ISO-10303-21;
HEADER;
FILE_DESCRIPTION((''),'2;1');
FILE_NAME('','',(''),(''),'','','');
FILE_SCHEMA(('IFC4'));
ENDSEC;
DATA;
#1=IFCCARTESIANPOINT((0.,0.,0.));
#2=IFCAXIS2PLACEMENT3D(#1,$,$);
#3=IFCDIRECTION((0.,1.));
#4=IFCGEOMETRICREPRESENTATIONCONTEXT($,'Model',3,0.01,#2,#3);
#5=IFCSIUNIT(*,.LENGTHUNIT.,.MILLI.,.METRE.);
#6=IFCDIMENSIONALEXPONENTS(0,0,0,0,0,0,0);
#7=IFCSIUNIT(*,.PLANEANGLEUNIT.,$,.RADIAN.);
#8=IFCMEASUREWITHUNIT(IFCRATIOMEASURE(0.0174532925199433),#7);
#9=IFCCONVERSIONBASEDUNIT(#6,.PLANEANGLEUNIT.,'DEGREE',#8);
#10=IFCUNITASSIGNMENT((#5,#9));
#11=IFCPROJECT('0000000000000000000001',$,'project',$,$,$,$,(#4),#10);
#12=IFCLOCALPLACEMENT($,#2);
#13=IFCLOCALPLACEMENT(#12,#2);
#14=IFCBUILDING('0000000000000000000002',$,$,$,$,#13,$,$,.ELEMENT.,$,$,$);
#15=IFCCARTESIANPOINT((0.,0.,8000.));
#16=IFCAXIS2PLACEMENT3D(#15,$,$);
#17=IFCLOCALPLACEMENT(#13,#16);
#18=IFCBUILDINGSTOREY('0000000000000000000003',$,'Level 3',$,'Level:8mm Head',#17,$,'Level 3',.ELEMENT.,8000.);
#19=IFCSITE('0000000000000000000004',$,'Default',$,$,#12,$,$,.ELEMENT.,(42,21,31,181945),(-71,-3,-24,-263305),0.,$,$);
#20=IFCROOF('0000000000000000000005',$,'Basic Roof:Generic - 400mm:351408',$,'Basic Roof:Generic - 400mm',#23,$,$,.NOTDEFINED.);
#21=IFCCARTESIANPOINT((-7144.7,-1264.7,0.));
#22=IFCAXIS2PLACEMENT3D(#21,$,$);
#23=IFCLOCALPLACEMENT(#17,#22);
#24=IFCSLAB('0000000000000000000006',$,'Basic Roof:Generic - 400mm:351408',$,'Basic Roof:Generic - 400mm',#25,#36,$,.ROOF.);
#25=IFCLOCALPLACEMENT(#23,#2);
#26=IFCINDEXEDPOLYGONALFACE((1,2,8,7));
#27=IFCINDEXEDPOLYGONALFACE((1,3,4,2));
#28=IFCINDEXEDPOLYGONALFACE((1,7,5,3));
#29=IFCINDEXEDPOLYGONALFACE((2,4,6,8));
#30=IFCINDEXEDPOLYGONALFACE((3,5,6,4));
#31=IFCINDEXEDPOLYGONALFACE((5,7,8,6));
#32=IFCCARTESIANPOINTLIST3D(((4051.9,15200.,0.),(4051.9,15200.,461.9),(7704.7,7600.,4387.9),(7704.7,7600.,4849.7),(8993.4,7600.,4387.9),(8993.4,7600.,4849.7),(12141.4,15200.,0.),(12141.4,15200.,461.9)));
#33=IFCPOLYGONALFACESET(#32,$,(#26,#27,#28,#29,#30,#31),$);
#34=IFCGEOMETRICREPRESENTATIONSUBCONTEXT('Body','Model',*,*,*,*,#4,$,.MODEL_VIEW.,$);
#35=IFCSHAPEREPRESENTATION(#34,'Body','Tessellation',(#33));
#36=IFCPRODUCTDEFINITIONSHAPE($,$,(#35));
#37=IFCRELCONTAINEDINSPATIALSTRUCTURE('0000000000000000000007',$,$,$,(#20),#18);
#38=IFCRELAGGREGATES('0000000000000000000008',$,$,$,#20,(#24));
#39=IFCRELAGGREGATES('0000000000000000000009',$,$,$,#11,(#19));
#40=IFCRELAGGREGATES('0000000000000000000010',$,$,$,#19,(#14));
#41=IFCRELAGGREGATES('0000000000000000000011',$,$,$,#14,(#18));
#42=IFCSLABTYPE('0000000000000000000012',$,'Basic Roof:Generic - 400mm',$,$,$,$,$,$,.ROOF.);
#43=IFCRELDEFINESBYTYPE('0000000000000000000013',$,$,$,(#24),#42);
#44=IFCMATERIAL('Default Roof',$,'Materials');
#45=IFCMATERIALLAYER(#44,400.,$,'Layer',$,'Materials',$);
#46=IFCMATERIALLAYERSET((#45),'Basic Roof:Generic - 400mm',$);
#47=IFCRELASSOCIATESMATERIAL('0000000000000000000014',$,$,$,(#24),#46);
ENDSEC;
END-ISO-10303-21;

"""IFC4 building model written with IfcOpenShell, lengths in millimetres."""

from ifc_helpers import new_model, entity, si_unit, converted_unit, direction, frame, origin, place, context, subcontext, project, spatial, polyline, outline, extrude, material, layer, layer_set, type_object, element, aggregate, save


model = new_model("IFC4")

# Units and contexts
model_context = context("Model", 3, precision=0.01, world=origin(), true_north=direction((0.0, 1.0)))
body_context = subcontext(model_context, "Body", "Model", "MODEL_VIEW")
ifc_project = project(units=[si_unit("LENGTHUNIT", "METRE", prefix="MILLI"), converted_unit("PLANEANGLEUNIT", "DEGREE", entity("IfcRatioMeasure", 0.0174532925199433), si_unit("PLANEANGLEUNIT", "RADIAN"), dimensions=[0, 0, 0, 0, 0, 0, 0])], contexts=[model_context])

# Site, building, storey
site_placement = place(None, origin())
site = spatial("IfcSite", under=ifc_project, at=site_placement, Name="Default", CompositionType="ELEMENT", RefLatitude=(42, 21, 31, 181945), RefLongitude=(-71, -3, -24, -263305), RefElevation=0.0)
building_placement = place(site_placement, origin())
building = spatial("IfcBuilding", under=site, at=building_placement, CompositionType="ELEMENT")
storey_placement = place(building_placement, frame((0.0, 0.0, 8000.0)))
storey = spatial("IfcBuildingStorey", under=building, at=storey_placement, Name="Level 3", ObjectType="Level:8mm Head", LongName="Level 3", CompositionType="ELEMENT", Elevation=8000.0)

# Roof, slab
roof_placement = place(storey_placement, frame((-7144.7, -1264.7, 0.0)))
roof = element("IfcRoof", 1, at=roof_placement, inside=storey, Name="Basic Roof:Generic - 400mm:351408", ObjectType="Basic Roof:Generic - 400mm", PredefinedType="NOTDEFINED")
ifc_material = material(Name="Default Roof", Category="Materials")
ifc_layer = layer(ifc_material, 400.0, Name="Layer", Category="Materials")
ifc_layer_set = layer_set([ifc_layer], Name="Basic Roof:Generic - 400mm")
slab_type_1 = type_object("IfcSlabType", Name="Basic Roof:Generic - 400mm", PredefinedType="ROOF")
slab_1_placement = place(roof_placement, origin())
slab_1 = element("IfcSlab", 2, at=slab_1_placement, type_object=slab_type_1, material=ifc_layer_set, Name="Basic Roof:Generic - 400mm:351408", ObjectType="Basic Roof:Generic - 400mm", PredefinedType="ROOF", context=body_context, shape_type="SweptSolid", body=[
    extrude(outline(polyline([(-4044.7, 4387.9), (-392.0, -4387.9), (896.7, -4387.9), (4044.7, 4387.9), (-4044.7, 4387.9)])), frame((8096.7, 11400.0, 2193.9), z_axis=(0.0, 0.5, 0.866025), x_axis=(1.0, 0.0, 0.0)), (0.0, -0.5, 0.866025), 461.9),
])
aggregate(roof, [slab_1])

save(model, "model.ifc")
